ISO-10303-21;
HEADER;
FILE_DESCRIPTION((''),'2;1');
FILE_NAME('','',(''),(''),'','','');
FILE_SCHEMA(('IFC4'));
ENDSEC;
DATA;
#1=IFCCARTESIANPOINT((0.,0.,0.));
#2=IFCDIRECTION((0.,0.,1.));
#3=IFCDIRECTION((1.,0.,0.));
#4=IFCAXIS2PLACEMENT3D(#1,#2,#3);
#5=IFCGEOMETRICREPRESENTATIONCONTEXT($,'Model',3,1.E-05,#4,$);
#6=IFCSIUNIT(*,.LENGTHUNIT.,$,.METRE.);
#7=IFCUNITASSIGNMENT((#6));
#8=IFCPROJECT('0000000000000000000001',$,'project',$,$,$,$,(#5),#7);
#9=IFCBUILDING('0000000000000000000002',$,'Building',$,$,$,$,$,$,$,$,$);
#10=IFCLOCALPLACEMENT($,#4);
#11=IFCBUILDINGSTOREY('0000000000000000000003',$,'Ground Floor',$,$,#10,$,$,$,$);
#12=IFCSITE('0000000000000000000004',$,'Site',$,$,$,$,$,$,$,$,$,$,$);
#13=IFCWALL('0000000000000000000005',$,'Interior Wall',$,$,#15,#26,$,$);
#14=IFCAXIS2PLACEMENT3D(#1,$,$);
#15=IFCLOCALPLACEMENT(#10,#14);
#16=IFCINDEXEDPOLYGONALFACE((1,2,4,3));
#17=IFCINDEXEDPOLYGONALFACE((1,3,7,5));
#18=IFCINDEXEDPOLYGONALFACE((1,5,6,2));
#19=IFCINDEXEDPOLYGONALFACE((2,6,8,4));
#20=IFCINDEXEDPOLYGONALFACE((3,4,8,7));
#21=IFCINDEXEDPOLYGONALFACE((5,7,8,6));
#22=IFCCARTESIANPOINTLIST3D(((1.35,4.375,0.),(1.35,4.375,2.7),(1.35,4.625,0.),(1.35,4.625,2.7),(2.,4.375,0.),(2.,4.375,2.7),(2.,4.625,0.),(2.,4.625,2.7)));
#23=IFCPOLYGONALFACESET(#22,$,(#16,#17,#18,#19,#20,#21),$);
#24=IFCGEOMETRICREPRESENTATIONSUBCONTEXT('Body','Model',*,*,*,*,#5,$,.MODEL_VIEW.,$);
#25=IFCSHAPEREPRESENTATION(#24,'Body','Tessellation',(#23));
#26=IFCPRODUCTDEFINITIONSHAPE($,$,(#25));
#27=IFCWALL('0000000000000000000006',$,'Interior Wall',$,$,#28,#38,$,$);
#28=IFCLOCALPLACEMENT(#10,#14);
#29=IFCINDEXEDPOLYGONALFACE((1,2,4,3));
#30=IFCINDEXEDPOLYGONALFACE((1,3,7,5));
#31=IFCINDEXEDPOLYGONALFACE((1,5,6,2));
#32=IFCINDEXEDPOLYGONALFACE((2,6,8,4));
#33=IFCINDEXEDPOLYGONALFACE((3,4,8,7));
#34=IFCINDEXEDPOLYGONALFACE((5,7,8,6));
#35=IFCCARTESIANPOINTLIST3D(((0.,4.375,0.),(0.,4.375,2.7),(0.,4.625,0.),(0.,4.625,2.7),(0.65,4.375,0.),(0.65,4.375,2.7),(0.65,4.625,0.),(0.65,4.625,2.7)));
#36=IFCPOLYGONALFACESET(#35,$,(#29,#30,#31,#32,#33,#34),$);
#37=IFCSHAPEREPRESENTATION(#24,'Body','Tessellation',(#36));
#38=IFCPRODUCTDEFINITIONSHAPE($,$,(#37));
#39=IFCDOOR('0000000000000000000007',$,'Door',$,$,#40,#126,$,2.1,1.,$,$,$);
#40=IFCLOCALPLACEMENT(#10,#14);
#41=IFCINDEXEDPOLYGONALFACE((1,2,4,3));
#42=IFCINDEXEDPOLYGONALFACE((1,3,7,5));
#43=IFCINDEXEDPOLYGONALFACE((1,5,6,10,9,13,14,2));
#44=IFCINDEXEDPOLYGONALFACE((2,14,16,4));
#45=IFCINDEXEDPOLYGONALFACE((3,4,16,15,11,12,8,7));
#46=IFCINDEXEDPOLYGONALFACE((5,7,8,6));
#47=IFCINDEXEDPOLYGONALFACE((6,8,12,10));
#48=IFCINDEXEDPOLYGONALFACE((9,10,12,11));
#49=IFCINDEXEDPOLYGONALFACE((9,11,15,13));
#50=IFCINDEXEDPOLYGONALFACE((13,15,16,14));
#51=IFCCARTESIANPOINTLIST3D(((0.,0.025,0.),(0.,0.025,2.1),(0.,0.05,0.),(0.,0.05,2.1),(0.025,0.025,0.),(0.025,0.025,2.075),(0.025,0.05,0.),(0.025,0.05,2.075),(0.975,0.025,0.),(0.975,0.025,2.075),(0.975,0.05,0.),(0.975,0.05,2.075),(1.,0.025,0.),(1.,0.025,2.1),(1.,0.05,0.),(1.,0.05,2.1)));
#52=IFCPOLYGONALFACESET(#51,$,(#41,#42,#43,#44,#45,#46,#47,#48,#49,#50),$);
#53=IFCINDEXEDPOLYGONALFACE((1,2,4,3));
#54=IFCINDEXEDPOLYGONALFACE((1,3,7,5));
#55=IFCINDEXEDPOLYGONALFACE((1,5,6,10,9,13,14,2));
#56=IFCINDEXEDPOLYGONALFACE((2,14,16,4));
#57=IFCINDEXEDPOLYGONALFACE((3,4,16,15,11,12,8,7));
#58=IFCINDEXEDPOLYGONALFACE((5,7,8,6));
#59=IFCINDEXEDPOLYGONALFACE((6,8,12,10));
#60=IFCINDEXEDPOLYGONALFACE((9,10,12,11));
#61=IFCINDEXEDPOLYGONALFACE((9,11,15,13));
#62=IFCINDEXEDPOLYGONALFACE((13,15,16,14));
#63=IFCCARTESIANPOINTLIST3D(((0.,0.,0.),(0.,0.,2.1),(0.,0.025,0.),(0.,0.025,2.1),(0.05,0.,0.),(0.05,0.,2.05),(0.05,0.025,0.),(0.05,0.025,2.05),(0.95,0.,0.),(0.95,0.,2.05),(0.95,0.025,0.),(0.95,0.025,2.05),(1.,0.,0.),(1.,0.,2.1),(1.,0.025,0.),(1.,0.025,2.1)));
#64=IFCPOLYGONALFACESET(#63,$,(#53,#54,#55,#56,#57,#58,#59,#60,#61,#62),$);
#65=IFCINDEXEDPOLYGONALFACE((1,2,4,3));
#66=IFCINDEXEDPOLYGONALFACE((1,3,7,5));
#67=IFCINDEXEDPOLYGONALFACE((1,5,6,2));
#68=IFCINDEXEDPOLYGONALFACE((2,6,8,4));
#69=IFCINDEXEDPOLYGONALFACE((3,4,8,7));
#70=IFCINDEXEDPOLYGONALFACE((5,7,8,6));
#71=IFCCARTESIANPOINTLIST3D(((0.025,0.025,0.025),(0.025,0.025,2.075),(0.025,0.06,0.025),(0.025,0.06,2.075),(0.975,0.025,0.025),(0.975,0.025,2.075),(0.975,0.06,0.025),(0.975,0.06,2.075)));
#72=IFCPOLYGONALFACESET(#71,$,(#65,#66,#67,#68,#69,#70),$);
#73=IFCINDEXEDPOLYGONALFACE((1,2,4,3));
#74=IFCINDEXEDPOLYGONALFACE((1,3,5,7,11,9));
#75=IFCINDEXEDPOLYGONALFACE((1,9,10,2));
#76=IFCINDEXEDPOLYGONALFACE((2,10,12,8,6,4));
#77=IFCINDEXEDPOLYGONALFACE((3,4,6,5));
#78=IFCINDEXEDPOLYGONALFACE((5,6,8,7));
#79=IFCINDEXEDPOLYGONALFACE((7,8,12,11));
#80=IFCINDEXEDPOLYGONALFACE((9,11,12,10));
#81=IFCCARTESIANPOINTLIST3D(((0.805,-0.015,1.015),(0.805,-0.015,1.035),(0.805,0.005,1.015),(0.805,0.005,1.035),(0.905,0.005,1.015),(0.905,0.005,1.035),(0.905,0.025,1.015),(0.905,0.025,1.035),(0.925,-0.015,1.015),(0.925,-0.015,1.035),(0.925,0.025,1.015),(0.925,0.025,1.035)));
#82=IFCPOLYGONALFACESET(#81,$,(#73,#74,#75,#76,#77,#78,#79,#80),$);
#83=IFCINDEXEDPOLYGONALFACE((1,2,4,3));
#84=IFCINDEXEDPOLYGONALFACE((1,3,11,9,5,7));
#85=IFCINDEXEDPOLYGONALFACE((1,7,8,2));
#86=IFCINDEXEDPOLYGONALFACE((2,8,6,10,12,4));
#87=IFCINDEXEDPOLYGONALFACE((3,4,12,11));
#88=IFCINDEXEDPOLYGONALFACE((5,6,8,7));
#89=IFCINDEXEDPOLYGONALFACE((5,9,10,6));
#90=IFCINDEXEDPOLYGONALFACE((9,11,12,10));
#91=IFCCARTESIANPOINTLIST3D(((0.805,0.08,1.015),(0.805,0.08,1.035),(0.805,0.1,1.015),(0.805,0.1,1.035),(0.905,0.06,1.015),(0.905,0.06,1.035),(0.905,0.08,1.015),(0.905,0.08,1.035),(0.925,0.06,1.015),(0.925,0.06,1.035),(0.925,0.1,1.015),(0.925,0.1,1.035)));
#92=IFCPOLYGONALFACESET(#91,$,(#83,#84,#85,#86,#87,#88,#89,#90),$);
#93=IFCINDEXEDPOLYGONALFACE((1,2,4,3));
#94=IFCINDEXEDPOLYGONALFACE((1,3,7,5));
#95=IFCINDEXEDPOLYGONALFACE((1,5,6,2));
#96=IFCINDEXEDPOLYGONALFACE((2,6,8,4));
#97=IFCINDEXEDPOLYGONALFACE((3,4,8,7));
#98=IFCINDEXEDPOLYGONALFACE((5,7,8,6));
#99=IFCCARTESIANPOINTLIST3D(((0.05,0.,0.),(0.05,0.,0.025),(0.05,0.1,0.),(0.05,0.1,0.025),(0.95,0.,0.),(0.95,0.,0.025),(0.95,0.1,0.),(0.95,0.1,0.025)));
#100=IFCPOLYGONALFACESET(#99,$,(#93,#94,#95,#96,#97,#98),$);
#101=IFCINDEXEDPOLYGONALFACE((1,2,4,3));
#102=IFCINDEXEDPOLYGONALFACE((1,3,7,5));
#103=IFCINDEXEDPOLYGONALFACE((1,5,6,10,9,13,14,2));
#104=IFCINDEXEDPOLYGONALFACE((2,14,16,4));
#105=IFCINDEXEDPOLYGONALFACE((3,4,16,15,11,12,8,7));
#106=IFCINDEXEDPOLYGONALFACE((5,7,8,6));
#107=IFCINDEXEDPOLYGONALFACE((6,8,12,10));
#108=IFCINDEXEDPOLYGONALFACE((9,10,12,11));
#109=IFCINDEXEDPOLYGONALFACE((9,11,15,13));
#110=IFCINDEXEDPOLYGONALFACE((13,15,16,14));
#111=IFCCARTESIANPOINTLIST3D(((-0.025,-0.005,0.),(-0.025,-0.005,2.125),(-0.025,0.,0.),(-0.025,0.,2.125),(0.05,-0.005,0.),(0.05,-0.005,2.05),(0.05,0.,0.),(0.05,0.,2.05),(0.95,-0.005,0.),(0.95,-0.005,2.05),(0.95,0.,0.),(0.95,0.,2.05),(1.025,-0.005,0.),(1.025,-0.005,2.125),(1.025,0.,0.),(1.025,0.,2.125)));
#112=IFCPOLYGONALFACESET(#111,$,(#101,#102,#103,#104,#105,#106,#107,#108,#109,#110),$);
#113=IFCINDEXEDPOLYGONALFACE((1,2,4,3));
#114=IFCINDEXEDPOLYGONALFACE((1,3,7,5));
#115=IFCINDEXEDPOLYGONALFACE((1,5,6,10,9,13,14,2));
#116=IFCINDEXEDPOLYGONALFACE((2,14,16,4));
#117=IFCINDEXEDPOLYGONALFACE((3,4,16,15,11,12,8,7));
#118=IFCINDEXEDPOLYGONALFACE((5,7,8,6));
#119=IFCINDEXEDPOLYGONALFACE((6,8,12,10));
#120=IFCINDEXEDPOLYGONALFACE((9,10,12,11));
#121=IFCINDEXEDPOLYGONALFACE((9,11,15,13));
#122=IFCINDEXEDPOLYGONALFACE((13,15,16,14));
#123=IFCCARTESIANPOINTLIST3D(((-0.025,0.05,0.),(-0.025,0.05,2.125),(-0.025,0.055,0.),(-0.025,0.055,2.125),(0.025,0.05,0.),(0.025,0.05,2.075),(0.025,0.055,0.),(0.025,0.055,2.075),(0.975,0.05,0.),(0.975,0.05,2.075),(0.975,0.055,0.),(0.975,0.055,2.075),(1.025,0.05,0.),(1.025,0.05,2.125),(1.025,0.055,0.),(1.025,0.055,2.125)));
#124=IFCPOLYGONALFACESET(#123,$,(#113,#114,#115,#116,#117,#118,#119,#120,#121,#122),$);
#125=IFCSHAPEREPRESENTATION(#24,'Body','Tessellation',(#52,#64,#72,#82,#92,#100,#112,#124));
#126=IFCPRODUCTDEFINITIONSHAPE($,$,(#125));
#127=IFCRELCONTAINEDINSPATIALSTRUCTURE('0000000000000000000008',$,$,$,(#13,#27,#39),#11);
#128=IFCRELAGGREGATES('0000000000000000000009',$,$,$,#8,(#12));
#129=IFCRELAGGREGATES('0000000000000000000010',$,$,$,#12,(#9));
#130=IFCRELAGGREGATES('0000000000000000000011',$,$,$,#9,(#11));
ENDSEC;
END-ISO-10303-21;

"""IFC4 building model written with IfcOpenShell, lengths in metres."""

from ifc_helpers import new_model, si_unit, frame, origin_with_axes, place, context, subcontext, project, spatial, line, indexed_curve, outline, extrude, element, save


model = new_model("IFC4")

# Units and contexts
model_context = context("Model", 3, precision=1e-05, world=origin_with_axes())
body_context = subcontext(model_context, "Body", "Model", "MODEL_VIEW")
ifc_project = project(units=[si_unit("LENGTHUNIT", "METRE")], contexts=[model_context])

# Site, building, storey
site = spatial("IfcSite", under=ifc_project, Name="Site")
building = spatial("IfcBuilding", under=site, Name="Building")
storey_placement = place(None, origin_with_axes())
storey = spatial("IfcBuildingStorey", under=building, at=storey_placement, Name="Ground Floor")

# Walls
for number, where, z_axis, x_axis, name in (
    (1, (2.0, 4.5, 0.0), (0.0, 0.0, 1.0), (-1.0, 0.0, 0.0), "Interior Wall"),
    (2, (0.65, 4.5, 0.0), (0.0, 0.0, 1.0), (-1.0, 0.0, 0.0), "Interior Wall"),
):
    element("IfcWall", number, at=place(storey_placement, frame(where, z_axis=z_axis, x_axis=x_axis)), inside=storey, Name=name, context=body_context, shape_type="SweptSolid", body=[
        extrude(outline(indexed_curve([(0.0, 0.0), (0.0, 0.25), (0.65, 0.25), (0.65, 0.0), (0.0, 0.0)], self_intersect=False)), frame((0.0, -0.125, 0.0), z_axis=(0.0, 0.0, 1.0), x_axis=(1.0, 0.0, 0.0)), (0.0, 0.0, 1.0), 2.7),
    ])

# Door
door_1_placement = place(storey_placement, origin_with_axes())
element("IfcDoor", 3, at=door_1_placement, inside=storey, Name="Door", OverallHeight=2.1, OverallWidth=1.0, context=body_context, shape_type="SweptSolid", body=[
    extrude(outline(indexed_curve([(0.0, 0.0), (0.0, 2.1), (1.0, 2.1), (1.0, 0.0), (0.975, 0.0), (0.975, 2.075), (0.025, 2.075), (0.025, 0.0)], segments=[line(1, 2, 3, 4, 5, 6, 7, 8, 1)])), frame((0.0, 0.025, 0.0), z_axis=(0.0, -1.0, 0.0), x_axis=(1.0, 0.0, 0.0)), (0.0, 0.0, -1.0), 0.025),
    extrude(outline(indexed_curve([(0.0, 0.0), (0.0, 2.1), (1.0, 2.1), (1.0, 0.0), (0.95, 0.0), (0.95, 2.05), (0.05, 2.05), (0.05, 0.0)], segments=[line(1, 2, 3, 4, 5, 6, 7, 8, 1)])), frame((0.0, 0.0, 0.0), z_axis=(0.0, -1.0, 0.0), x_axis=(1.0, 0.0, 0.0)), (0.0, 0.0, -1.0), 0.025),
    extrude(outline(indexed_curve([(0.0, 0.0), (0.95, 0.0), (0.95, 0.035), (0.0, 0.035)], segments=[line(1, 2, 3, 4, 1)])), frame((0.025, 0.025, 0.025), z_axis=(0.0, 0.0, 1.0), x_axis=(1.0, 0.0, 0.0)), (0.0, 0.0, 1.0), 2.05),
    extrude(outline(indexed_curve([(0.0, 0.0), (0.0, -0.04), (-0.12, -0.04), (-0.12, -0.02), (-0.02, -0.02), (-0.02, 0.0)], segments=[line(1, 2, 3, 4, 5, 6, 1)])), frame((0.925, 0.025, 1.015), z_axis=(0.0, 0.0, 1.0), x_axis=(1.0, 0.0, 0.0)), (0.0, 0.0, 1.0), 0.02),
    extrude(outline(indexed_curve([(0.0, 0.0), (0.0, 0.04), (-0.12, 0.04), (-0.12, 0.02), (-0.02, 0.02), (-0.02, 0.0)], segments=[line(1, 2, 3, 4, 5, 6, 1)])), frame((0.925, 0.06, 1.015), z_axis=(0.0, 0.0, 1.0), x_axis=(1.0, 0.0, 0.0)), (0.0, 0.0, 1.0), 0.02),
    extrude(outline(indexed_curve([(0.0, 0.0), (0.9, 0.0), (0.9, 0.1), (0.0, 0.1)], segments=[line(1, 2, 3, 4, 1)])), frame((0.05, 0.0, 0.0), z_axis=(0.0, 0.0, 1.0), x_axis=(1.0, 0.0, 0.0)), (0.0, 0.0, 1.0), 0.025),
    extrude(outline(indexed_curve([(0.0, 0.0), (0.0, 2.125), (1.05, 2.125), (1.05, 0.0), (0.975, 0.0), (0.975, 2.05), (0.075, 2.05), (0.075, 0.0)], segments=[line(1, 2, 3, 4, 5, 6, 7, 8, 1)])), frame((-0.025, -0.005, 0.0), z_axis=(0.0, -1.0, 0.0), x_axis=(1.0, 0.0, 0.0)), (0.0, 0.0, -1.0), 0.005),
    extrude(outline(indexed_curve([(0.0, 0.0), (0.0, 2.125), (1.05, 2.125), (1.05, 0.0), (1.0, 0.0), (1.0, 2.075), (0.05, 2.075), (0.05, 0.0)], segments=[line(1, 2, 3, 4, 5, 6, 7, 8, 1)])), frame((-0.025, 0.05, 0.0), z_axis=(0.0, -1.0, 0.0), x_axis=(1.0, 0.0, 0.0)), (0.0, 0.0, -1.0), 0.005),
])

save(model, "model.ifc")
